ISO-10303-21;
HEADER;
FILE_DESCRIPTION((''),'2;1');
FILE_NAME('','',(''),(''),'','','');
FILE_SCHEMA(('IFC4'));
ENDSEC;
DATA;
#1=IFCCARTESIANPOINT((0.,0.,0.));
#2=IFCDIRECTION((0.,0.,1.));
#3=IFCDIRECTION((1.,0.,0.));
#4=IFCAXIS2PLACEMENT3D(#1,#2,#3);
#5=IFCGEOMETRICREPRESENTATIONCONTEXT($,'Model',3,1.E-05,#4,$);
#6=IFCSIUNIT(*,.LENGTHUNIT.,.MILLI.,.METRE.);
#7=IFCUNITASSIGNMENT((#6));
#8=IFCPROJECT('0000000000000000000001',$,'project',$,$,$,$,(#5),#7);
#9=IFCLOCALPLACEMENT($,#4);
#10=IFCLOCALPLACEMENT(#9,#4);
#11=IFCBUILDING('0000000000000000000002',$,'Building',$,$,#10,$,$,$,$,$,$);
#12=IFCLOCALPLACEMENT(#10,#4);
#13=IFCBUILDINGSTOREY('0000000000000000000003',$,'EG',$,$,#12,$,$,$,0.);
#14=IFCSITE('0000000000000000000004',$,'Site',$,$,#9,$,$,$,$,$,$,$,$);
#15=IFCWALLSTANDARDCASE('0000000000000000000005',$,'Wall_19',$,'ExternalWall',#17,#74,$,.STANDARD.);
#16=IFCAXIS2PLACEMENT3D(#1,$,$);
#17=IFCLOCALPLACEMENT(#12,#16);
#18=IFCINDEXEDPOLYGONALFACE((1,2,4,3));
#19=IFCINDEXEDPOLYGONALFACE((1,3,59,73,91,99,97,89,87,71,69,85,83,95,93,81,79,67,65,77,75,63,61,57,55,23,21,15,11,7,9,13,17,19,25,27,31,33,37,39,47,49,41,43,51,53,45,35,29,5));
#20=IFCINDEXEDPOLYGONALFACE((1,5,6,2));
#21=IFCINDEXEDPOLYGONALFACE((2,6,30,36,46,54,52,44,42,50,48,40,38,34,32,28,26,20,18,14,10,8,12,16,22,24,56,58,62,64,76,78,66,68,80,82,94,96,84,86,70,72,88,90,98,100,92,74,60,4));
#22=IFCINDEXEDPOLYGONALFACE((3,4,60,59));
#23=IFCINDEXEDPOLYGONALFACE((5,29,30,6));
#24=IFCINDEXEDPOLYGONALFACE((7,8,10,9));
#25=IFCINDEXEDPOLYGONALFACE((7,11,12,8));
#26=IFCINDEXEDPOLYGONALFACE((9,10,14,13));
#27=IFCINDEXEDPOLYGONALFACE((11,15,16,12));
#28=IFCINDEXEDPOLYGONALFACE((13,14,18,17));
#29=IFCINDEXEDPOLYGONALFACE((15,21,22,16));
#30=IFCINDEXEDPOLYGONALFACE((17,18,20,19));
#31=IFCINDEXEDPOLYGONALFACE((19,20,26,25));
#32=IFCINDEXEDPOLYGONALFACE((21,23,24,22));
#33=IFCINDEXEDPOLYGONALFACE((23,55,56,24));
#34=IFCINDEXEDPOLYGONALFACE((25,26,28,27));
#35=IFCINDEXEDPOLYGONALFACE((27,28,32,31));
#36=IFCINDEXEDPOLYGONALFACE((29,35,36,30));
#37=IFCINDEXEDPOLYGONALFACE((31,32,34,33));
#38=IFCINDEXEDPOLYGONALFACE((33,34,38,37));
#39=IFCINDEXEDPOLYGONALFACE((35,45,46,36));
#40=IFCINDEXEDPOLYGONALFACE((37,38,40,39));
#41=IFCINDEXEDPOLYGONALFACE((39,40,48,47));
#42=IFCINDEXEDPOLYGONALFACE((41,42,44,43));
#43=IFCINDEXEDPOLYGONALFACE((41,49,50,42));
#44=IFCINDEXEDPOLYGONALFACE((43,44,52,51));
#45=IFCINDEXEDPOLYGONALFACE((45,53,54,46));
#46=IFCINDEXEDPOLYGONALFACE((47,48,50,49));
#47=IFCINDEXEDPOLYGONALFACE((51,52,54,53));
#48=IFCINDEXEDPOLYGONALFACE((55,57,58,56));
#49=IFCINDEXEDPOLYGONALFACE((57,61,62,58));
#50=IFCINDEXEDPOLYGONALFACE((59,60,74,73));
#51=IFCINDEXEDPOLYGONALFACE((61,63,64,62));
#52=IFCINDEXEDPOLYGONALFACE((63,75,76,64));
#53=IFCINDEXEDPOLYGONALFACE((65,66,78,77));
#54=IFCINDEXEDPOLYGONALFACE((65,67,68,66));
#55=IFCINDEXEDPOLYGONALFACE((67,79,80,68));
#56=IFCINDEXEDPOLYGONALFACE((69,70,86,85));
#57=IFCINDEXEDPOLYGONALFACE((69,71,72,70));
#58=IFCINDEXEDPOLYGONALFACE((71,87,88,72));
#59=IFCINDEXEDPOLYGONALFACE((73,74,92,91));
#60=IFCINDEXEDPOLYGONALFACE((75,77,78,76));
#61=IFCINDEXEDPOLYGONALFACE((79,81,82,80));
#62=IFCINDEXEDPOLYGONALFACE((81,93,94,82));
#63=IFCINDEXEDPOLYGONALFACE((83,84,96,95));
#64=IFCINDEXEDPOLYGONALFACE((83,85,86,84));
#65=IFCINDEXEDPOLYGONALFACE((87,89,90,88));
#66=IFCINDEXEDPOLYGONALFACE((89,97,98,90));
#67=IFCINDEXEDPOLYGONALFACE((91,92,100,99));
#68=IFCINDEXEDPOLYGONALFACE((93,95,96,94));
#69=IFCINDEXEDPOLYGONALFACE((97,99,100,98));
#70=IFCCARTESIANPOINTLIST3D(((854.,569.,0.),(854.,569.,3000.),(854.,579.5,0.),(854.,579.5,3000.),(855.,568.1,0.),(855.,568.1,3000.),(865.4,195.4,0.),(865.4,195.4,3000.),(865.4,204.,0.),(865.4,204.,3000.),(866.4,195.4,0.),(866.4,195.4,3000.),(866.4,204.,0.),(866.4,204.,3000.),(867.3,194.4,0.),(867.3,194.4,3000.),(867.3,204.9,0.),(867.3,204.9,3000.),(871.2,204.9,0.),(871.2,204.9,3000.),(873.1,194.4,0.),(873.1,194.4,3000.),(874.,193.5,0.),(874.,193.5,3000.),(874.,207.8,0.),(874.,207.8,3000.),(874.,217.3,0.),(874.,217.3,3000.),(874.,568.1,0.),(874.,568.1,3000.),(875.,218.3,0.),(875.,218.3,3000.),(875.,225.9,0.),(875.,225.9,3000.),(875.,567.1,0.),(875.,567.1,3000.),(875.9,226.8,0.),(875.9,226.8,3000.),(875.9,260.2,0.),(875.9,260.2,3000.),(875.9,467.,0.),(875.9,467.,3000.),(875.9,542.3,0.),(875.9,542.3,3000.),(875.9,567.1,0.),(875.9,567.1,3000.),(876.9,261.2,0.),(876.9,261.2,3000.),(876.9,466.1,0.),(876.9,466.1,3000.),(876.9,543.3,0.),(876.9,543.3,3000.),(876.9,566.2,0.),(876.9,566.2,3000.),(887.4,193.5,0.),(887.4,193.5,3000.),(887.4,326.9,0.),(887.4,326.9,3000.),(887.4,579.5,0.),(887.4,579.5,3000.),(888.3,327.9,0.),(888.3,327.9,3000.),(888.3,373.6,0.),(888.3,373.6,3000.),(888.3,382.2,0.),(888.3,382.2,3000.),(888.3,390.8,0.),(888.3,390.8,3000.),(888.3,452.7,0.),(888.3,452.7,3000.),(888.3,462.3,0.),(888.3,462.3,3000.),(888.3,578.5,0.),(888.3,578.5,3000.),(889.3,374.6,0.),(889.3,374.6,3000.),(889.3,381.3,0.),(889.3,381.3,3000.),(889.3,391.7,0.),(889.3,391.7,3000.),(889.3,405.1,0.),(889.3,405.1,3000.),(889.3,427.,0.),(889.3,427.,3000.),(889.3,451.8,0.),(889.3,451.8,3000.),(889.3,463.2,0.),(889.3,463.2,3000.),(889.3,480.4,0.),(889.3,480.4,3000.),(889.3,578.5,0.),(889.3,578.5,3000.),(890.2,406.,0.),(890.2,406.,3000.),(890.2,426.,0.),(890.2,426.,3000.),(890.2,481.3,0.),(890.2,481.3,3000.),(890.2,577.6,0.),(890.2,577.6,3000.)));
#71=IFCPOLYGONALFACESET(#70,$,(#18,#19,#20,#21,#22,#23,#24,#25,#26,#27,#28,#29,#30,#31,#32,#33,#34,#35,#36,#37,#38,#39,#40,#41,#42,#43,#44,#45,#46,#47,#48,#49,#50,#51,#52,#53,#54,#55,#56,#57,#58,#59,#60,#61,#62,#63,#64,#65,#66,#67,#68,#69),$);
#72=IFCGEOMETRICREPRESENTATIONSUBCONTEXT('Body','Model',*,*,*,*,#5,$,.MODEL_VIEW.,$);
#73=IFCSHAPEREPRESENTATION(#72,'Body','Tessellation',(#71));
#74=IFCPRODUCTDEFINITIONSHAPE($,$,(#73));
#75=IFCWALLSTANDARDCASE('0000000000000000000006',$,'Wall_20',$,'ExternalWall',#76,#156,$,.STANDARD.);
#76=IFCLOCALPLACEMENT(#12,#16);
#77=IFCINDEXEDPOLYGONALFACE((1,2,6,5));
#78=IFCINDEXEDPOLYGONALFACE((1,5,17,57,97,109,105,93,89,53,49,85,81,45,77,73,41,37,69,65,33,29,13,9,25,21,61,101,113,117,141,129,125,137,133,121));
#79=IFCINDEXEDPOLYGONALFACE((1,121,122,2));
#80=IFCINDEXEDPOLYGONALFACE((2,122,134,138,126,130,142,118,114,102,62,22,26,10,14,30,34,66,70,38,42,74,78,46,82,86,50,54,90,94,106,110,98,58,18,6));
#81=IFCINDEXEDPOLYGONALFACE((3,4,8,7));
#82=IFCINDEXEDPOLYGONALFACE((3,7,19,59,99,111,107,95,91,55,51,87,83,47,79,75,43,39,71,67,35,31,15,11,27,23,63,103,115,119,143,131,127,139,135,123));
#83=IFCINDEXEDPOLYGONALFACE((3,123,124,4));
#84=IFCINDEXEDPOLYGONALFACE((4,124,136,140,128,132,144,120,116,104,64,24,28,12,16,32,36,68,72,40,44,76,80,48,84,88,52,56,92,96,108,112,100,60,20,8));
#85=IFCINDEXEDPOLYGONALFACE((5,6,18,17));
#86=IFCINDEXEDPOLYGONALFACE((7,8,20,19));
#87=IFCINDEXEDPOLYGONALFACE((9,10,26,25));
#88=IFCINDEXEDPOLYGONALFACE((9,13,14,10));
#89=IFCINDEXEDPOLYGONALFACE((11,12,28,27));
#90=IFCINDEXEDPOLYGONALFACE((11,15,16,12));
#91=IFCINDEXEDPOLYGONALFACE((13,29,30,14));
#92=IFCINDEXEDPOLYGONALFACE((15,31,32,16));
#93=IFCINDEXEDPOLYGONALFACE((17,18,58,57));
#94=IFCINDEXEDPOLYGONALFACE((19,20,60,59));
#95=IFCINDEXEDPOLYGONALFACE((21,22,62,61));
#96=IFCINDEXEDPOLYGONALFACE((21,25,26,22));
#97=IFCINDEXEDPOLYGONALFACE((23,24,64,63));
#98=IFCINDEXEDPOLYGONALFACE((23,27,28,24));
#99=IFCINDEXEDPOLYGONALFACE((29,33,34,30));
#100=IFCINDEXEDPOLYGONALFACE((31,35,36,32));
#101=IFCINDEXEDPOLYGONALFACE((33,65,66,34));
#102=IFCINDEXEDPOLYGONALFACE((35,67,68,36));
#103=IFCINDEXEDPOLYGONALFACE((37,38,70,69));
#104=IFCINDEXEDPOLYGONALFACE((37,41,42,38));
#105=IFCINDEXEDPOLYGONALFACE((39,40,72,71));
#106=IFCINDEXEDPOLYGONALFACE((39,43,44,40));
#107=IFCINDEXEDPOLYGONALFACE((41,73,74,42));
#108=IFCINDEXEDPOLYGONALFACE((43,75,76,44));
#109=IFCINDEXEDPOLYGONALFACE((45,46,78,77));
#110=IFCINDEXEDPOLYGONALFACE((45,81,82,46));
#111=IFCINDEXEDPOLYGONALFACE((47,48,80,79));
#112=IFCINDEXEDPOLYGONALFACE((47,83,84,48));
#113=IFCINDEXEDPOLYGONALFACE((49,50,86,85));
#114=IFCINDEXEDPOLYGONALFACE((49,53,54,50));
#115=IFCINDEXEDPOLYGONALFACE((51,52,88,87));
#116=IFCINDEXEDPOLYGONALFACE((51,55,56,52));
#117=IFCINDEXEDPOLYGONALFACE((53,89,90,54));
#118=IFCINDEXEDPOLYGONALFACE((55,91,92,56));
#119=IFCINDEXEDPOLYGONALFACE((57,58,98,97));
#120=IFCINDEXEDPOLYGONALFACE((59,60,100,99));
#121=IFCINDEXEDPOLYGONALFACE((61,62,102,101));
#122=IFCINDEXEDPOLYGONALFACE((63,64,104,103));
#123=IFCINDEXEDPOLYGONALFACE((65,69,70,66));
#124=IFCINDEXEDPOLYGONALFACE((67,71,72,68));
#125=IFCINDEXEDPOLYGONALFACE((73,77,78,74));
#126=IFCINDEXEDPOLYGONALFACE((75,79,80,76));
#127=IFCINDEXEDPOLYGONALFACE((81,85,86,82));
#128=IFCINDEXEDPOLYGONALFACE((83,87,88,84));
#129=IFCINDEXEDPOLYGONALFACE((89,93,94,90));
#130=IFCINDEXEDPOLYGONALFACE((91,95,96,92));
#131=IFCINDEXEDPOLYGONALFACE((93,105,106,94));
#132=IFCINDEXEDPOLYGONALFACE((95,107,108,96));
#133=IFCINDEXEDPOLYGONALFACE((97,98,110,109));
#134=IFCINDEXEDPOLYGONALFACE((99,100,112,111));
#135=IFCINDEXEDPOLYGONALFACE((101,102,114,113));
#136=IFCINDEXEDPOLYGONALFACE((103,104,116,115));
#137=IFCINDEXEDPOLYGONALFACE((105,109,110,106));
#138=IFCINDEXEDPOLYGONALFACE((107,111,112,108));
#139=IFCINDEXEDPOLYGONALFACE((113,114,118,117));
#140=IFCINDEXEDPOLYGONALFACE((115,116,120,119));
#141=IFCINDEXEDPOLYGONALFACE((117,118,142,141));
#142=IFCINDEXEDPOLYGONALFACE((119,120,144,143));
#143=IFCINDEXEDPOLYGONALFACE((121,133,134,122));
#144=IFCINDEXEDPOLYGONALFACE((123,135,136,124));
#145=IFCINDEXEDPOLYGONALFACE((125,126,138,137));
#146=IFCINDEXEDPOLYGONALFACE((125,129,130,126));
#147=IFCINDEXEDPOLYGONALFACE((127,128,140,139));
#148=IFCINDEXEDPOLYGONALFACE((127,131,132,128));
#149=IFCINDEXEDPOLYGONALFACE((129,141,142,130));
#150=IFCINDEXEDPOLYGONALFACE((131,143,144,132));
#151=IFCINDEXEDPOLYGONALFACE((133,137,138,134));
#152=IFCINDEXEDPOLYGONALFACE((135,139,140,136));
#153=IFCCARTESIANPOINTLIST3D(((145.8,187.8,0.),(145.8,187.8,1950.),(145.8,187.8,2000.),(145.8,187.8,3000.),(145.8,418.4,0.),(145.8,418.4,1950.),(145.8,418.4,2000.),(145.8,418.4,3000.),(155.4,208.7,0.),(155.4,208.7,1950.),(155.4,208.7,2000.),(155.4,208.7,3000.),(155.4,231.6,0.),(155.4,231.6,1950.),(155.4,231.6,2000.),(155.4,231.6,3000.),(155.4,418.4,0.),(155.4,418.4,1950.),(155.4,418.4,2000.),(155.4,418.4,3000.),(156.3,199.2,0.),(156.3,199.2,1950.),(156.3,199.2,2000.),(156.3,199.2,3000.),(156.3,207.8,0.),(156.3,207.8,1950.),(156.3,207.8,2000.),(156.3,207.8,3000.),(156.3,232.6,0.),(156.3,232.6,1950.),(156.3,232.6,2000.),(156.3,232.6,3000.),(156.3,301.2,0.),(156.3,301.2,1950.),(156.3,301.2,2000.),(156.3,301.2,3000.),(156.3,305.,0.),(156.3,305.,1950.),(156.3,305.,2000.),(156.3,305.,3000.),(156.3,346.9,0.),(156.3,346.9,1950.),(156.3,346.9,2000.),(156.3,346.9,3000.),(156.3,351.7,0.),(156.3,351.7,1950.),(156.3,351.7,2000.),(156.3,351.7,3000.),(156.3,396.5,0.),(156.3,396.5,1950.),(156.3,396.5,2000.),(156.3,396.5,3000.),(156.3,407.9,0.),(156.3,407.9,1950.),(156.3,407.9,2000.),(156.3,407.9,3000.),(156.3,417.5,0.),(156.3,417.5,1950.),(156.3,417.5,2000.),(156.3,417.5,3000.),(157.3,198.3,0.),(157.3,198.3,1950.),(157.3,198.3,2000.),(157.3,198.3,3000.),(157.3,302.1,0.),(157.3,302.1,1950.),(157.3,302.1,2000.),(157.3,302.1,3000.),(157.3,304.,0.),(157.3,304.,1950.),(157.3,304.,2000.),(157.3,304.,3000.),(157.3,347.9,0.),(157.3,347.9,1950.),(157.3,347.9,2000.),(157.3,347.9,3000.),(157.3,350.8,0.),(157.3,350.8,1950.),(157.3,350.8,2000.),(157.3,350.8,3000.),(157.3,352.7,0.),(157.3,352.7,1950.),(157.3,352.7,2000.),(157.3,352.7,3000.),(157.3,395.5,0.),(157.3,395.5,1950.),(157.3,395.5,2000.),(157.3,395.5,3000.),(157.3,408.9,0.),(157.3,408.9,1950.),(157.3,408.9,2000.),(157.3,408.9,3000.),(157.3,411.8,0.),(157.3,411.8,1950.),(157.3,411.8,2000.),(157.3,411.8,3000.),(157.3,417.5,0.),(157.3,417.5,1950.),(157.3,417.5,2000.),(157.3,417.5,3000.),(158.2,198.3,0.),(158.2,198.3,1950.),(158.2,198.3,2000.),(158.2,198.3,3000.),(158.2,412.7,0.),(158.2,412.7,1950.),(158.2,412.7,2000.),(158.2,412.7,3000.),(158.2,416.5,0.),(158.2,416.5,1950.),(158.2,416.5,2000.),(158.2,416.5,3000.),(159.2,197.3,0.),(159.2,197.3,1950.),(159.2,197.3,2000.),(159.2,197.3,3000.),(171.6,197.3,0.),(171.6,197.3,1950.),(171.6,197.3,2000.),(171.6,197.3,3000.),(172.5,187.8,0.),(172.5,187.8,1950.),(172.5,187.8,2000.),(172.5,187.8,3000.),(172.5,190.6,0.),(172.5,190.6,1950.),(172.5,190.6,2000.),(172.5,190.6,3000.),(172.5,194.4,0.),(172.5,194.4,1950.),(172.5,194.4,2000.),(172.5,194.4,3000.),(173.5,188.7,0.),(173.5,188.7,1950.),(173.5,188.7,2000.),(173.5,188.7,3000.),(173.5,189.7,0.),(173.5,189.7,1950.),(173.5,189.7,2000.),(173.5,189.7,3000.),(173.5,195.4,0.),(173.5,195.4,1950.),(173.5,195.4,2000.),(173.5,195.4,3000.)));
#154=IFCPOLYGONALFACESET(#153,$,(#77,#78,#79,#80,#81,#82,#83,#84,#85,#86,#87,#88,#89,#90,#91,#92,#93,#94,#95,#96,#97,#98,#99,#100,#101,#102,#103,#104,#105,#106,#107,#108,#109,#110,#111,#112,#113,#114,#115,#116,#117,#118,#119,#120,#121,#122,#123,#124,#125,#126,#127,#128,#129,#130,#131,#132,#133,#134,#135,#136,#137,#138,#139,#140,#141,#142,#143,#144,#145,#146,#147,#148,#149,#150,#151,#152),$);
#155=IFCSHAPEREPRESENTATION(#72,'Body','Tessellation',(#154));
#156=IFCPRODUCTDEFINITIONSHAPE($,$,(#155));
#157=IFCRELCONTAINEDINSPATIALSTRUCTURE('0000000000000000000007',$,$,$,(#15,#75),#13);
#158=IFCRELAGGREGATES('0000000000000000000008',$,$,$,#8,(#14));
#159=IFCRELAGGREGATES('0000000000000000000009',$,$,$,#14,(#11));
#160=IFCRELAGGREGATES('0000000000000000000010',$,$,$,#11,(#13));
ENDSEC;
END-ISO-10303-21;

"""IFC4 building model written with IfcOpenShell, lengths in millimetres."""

from ifc_helpers import new_model, si_unit, frame, origin_with_axes, place, context, subcontext, project, spatial, polyline, rectangle, outline, extrude, element, save


model = new_model("IFC4")

# Units and contexts
model_context = context("Model", 3, precision=1e-05, world=origin_with_axes())
body_context = subcontext(model_context, "Body", "Model", "MODEL_VIEW")
ifc_project = project(units=[si_unit("LENGTHUNIT", "METRE", prefix="MILLI")], contexts=[model_context])

# Site, building, storey
site_placement = place(None, origin_with_axes())
site = spatial("IfcSite", under=ifc_project, at=site_placement, Name="Site")
building_placement = place(site_placement, origin_with_axes())
building = spatial("IfcBuilding", under=site, at=building_placement, Name="Building")
storey_placement = place(building_placement, origin_with_axes())
storey = spatial("IfcBuildingStorey", under=building, at=storey_placement, Name="EG", Elevation=0.0)

# Wall
wall_1_placement = place(storey_placement, origin_with_axes())
element("IfcWallStandardCase", 1, at=wall_1_placement, inside=storey, Name="Wall_19", ObjectType="ExternalWall", PredefinedType="STANDARD", context=body_context, shape_type="SweptSolid", body=[
    extrude(outline(polyline([(874.0, 193.5, 0.0), (873.1, 194.4, 0.0), (867.3, 194.4, 0.0), (866.4, 195.4, 0.0), (865.4, 195.4, 0.0), (865.4, 204.0, 0.0), (866.4, 204.0, 0.0), (867.3, 204.9, 0.0), (871.2, 204.9, 0.0), (874.0, 207.8, 0.0), (874.0, 217.3, 0.0), (875.0, 218.3, 0.0), (875.0, 225.9, 0.0), (875.9, 226.8, 0.0), (875.9, 260.2, 0.0), (876.9, 261.2, 0.0), (876.9, 466.1, 0.0), (875.9, 467.0, 0.0), (875.9, 542.3, 0.0), (876.9, 543.3, 0.0), (876.9, 566.2, 0.0), (875.9, 567.1, 0.0), (875.0, 567.1, 0.0), (874.0, 568.1, 0.0), (855.0, 568.1, 0.0), (854.0, 569.0, 0.0), (854.0, 579.5, 0.0), (887.4, 579.5, 0.0), (888.3, 578.5, 0.0), (889.3, 578.5, 0.0), (890.2, 577.6, 0.0), (890.2, 481.3, 0.0), (889.3, 480.4, 0.0), (889.3, 463.2, 0.0), (888.3, 462.3, 0.0), (888.3, 452.7, 0.0), (889.3, 451.8, 0.0), (889.3, 427.0, 0.0), (890.2, 426.0, 0.0), (890.2, 406.0, 0.0), (889.3, 405.1, 0.0), (889.3, 391.7, 0.0), (888.3, 390.8, 0.0), (888.3, 382.2, 0.0), (889.3, 381.3, 0.0), (889.3, 374.6, 0.0), (888.3, 373.6, 0.0), (888.3, 327.9, 0.0), (887.4, 326.9, 0.0), (887.4, 193.5, 0.0), (874.0, 193.5, 0.0)])), origin_with_axes(), (0.0, 0.0, 1.0), 3000.0),
])

# Wall, opening
wall_2_placement = place(storey_placement, origin_with_axes())
wall_2 = element("IfcWallStandardCase", 2, at=wall_2_placement, inside=storey, Name="Wall_20", ObjectType="ExternalWall", PredefinedType="STANDARD", context=body_context, shape_type="SweptSolid", body=[
    extrude(outline(polyline([(145.8, 187.8, 0.0), (145.8, 418.4, 0.0), (155.4, 418.4, 0.0), (156.3, 417.5, 0.0), (157.3, 417.5, 0.0), (158.2, 416.5, 0.0), (158.2, 412.7, 0.0), (157.3, 411.8, 0.0), (157.3, 408.9, 0.0), (156.3, 407.9, 0.0), (156.3, 396.5, 0.0), (157.3, 395.5, 0.0), (157.3, 352.7, 0.0), (156.3, 351.7, 0.0), (157.3, 350.8, 0.0), (157.3, 347.9, 0.0), (156.3, 346.9, 0.0), (156.3, 305.0, 0.0), (157.3, 304.0, 0.0), (157.3, 302.1, 0.0), (156.3, 301.2, 0.0), (156.3, 232.6, 0.0), (155.4, 231.6, 0.0), (155.4, 208.7, 0.0), (156.3, 207.8, 0.0), (156.3, 199.2, 0.0), (157.3, 198.3, 0.0), (158.2, 198.3, 0.0), (159.2, 197.3, 0.0), (171.6, 197.3, 0.0), (173.5, 195.4, 0.0), (172.5, 194.4, 0.0), (172.5, 190.6, 0.0), (173.5, 189.7, 0.0), (173.5, 188.7, 0.0), (172.5, 187.8, 0.0), (145.8, 187.8, 0.0)])), origin_with_axes(), (0.0, 0.0, 1.0), 3000.0),
])
opening_1_placement = place(wall_2_placement, origin_with_axes())
element("IfcOpeningElement", 3, at=opening_1_placement, inside=storey, cuts=wall_2, context=body_context, shape_type="SweptSolid", body=[
    extrude(rectangle(XDim=600.0, YDim=27.6), frame((159.6, 192.5, 1950.0), z_axis=(0.0, 0.0, 1.0), x_axis=(0.0, -1.0, 0.0)), (0.0, 0.0, 1.0), 50.0),
])

save(model, "model.ifc")
